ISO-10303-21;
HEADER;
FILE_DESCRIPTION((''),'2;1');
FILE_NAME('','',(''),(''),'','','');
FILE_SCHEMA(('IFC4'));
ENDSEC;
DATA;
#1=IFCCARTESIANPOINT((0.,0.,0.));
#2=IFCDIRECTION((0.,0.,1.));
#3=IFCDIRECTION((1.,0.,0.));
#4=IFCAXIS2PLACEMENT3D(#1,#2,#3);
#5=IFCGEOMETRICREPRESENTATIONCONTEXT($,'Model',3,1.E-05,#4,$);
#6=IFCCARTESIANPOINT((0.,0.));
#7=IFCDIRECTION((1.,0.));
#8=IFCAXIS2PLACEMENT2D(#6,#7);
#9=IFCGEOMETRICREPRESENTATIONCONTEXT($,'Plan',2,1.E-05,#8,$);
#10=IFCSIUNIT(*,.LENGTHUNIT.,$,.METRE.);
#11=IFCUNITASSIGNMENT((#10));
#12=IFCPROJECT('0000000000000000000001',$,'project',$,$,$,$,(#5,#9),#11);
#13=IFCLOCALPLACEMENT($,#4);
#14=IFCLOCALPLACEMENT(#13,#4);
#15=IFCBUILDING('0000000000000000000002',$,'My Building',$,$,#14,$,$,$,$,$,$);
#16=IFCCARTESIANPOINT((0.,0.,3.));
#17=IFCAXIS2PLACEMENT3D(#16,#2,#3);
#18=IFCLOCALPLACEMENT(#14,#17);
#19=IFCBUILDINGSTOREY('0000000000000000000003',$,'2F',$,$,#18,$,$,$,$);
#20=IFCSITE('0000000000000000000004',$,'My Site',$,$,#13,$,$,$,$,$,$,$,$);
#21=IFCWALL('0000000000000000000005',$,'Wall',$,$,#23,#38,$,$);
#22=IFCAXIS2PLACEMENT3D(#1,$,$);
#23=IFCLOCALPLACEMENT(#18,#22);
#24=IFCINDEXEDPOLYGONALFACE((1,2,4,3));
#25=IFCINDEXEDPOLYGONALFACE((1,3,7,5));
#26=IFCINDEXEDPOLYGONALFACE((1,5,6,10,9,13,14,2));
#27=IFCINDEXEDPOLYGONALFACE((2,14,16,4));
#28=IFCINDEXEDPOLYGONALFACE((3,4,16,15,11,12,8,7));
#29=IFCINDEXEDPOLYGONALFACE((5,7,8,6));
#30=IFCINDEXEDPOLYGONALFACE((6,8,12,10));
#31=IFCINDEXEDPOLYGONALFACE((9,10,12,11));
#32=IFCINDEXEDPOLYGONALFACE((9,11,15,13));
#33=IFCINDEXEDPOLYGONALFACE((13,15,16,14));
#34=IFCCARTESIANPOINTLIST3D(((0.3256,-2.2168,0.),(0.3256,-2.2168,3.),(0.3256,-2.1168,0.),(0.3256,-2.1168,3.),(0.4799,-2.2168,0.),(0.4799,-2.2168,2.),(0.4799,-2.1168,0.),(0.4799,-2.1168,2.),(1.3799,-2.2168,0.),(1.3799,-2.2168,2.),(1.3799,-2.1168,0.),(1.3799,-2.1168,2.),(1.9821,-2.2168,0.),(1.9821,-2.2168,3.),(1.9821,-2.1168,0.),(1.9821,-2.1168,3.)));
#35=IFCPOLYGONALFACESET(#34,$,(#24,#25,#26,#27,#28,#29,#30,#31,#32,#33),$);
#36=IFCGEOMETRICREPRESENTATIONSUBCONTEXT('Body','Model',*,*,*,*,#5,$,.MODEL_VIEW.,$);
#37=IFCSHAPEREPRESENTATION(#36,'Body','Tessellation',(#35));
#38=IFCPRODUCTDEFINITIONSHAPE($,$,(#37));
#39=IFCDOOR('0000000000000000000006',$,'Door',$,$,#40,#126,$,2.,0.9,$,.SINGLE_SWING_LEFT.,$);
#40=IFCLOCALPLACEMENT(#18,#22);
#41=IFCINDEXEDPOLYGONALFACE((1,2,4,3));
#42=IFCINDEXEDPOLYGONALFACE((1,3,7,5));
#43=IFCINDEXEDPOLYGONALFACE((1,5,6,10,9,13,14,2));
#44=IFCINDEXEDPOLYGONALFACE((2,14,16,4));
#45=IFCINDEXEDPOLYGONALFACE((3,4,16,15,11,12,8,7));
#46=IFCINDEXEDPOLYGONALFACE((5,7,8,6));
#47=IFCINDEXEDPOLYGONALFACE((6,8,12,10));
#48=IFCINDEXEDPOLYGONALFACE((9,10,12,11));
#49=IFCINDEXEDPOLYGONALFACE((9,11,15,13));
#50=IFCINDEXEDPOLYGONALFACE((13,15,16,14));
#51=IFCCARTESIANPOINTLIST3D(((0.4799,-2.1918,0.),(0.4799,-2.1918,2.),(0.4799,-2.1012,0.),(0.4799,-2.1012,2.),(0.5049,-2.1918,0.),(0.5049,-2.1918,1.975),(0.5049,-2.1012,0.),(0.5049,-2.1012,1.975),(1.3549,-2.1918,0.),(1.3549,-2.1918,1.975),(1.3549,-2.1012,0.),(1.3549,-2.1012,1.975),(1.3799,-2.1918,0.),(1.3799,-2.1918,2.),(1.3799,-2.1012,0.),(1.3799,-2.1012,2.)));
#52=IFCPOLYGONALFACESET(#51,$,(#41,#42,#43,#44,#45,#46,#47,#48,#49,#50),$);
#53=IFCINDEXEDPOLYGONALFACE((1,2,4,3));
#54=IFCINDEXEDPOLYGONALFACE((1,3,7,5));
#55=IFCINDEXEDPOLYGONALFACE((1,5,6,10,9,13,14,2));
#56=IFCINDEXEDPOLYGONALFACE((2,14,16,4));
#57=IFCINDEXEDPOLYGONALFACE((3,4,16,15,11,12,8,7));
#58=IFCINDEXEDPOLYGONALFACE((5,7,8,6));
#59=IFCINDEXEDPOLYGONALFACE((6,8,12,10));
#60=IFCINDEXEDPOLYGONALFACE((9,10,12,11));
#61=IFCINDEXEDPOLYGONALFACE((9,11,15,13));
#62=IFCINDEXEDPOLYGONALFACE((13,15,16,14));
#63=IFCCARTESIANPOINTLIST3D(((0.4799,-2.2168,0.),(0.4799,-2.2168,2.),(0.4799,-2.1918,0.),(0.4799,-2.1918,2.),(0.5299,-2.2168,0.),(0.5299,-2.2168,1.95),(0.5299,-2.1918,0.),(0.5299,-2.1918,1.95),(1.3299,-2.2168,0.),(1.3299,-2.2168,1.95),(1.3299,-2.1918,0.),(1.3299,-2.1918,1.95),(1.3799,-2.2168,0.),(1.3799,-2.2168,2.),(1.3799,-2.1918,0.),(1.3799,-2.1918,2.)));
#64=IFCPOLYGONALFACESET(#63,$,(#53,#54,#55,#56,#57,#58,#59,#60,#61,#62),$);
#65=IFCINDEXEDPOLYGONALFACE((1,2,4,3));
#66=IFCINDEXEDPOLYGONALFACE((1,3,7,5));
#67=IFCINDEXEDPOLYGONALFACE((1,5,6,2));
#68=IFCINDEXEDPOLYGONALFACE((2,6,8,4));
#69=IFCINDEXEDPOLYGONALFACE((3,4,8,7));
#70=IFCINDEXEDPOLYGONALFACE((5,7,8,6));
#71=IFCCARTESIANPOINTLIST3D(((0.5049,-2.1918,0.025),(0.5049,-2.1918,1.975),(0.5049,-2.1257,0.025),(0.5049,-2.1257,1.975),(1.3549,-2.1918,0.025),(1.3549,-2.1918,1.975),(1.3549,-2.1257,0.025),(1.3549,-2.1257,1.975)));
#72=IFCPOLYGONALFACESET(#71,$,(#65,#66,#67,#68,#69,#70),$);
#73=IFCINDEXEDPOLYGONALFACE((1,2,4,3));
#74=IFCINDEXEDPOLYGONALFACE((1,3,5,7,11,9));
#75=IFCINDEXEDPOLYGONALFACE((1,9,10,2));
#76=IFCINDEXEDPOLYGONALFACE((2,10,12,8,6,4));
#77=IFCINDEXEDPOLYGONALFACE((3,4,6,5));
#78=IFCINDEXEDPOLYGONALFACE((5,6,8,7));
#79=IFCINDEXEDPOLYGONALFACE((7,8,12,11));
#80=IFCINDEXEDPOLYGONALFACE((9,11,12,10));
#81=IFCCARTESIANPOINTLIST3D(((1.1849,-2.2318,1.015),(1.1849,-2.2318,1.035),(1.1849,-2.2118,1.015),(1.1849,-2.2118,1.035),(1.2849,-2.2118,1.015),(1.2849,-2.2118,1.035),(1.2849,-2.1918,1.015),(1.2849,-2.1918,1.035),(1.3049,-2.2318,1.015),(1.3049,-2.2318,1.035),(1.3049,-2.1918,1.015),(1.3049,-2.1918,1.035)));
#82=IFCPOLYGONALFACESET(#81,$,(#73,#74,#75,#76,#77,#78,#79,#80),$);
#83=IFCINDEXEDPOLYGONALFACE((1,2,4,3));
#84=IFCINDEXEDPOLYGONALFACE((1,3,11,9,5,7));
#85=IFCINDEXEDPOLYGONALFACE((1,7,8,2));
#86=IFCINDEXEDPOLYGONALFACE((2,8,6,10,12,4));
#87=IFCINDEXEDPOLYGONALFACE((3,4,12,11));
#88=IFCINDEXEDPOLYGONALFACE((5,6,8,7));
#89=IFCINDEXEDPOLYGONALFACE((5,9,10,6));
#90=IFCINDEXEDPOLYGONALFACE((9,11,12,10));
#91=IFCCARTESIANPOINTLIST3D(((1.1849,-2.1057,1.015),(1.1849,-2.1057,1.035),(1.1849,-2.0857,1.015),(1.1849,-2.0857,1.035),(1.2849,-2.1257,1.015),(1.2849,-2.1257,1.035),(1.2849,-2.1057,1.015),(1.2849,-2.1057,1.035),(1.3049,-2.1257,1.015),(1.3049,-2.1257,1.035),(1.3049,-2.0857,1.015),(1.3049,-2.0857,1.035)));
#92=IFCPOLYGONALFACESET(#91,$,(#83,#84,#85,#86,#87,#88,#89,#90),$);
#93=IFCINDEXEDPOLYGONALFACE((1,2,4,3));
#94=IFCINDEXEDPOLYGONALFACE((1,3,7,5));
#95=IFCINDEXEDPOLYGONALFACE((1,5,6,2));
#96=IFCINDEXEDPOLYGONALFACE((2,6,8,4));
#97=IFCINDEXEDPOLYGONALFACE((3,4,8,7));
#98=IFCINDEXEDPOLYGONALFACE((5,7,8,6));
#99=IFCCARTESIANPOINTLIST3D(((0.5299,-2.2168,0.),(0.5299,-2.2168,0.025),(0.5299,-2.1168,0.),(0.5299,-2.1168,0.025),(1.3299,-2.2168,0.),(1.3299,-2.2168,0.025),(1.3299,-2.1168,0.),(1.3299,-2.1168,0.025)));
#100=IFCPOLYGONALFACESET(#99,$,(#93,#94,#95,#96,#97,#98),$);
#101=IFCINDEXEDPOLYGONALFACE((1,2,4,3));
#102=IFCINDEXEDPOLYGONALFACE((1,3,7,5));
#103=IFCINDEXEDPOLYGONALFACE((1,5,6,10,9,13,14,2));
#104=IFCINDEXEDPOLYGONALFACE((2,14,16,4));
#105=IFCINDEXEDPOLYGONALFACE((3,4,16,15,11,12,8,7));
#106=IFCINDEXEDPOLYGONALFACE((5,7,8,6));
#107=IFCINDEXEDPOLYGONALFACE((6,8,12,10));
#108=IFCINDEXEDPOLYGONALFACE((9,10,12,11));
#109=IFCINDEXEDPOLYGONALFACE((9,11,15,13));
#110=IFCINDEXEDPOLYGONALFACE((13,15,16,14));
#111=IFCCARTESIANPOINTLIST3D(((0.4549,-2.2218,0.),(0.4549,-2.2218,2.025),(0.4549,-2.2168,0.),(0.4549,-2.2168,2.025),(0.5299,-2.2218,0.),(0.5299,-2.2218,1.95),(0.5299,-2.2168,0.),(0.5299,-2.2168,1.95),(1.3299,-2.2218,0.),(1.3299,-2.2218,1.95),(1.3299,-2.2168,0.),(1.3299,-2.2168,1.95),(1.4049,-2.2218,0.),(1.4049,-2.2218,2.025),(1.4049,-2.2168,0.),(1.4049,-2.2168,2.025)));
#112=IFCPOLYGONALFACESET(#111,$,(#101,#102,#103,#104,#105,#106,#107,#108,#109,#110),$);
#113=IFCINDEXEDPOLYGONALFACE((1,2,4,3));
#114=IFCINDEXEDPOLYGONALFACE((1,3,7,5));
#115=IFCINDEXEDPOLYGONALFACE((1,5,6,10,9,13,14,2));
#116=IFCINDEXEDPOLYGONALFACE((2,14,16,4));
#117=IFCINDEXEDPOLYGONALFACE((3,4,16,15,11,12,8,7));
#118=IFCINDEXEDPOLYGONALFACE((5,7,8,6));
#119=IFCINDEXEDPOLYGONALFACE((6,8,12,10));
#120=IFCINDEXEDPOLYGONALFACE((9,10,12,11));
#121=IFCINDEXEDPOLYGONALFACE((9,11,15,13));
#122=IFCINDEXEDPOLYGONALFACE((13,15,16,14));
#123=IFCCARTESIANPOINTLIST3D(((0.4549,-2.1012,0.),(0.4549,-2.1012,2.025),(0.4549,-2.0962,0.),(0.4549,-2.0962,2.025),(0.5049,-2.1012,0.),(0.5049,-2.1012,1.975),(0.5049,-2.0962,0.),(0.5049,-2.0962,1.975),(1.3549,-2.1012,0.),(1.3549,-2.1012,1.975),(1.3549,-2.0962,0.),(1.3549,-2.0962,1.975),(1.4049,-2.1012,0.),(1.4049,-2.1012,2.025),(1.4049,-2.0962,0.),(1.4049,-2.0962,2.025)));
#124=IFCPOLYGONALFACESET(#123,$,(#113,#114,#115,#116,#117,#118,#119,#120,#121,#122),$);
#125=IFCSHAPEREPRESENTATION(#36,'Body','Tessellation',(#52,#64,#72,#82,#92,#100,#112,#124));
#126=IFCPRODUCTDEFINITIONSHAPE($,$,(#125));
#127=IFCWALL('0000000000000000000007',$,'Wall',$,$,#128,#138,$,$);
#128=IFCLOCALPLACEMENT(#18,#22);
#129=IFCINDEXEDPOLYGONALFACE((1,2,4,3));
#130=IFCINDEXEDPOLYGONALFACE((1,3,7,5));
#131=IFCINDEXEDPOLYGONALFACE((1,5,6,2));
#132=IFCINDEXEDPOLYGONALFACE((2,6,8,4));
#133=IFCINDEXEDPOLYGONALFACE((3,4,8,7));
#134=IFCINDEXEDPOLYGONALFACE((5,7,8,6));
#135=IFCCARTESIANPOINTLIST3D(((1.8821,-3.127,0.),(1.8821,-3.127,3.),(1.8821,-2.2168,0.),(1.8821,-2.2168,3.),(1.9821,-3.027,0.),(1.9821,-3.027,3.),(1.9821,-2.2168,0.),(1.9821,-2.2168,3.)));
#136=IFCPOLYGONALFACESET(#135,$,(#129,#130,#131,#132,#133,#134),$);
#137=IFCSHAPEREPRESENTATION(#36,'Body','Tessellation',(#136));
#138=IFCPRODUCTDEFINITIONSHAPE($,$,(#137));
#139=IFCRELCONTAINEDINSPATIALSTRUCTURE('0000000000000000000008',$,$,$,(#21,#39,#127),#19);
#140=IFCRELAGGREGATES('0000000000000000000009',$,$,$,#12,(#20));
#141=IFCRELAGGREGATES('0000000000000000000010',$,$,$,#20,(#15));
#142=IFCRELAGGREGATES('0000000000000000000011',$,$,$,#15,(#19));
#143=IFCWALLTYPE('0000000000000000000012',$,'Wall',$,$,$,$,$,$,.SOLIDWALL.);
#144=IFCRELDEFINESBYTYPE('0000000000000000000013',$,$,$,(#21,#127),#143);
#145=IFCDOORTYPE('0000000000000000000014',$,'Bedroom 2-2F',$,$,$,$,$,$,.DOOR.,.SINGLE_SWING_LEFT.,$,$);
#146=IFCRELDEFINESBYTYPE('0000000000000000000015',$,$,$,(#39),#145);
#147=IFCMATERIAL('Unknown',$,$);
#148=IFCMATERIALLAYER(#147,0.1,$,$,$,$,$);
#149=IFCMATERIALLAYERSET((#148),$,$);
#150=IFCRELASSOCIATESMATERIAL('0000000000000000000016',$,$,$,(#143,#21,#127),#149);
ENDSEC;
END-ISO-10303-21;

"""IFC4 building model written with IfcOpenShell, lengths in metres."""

from ifc_helpers import new_model, entity, si_unit, frame, origin_with_axes, origin_2d_with_axis, place, context, subcontext, project, spatial, line, indexed_curve, outline, extrude, shape, source, transform, mapped, material, layer, layer_set, layer_usage, type_object, type_shapes, element, fill, save


model = new_model("IFC4")

# Units and contexts
model_context = context("Model", 3, precision=1e-05, world=origin_with_axes())
plan_context = context("Plan", 2, precision=1e-05, world=origin_2d_with_axis())
body_context_1 = subcontext(model_context, "Body", "Model", "MODEL_VIEW")
body_context_2 = subcontext(plan_context, "Body", "Plan", "PLAN_VIEW")
ifc_project = project(units=[si_unit("LENGTHUNIT", "METRE")], contexts=[model_context, plan_context])

# Site, building, storey
site_placement = place(None, origin_with_axes())
site = spatial("IfcSite", under=ifc_project, at=site_placement, Name="My Site")
building_placement = place(site_placement, origin_with_axes())
building = spatial("IfcBuilding", under=site, at=building_placement, Name="My Building")
storey_placement = place(building_placement, frame((0.0, 0.0, 3.0), z_axis=(0.0, 0.0, 1.0), x_axis=(1.0, 0.0, 0.0)))
storey = spatial("IfcBuildingStorey", under=building, at=storey_placement, Name="2F")

# Shared definitions
ifc_material = material(Name="Unknown")

# Shared definitions
ifc_layer = layer(ifc_material, 0.1)
ifc_layer_set = layer_set([ifc_layer])
wall_type = type_object("IfcWallType", Name="Wall", PredefinedType="SOLIDWALL", material=ifc_layer_set)

# Wall, opening, door
ifc_layer_usage_1 = layer_usage(ifc_layer_set, "AXIS2", "POSITIVE", 0.0)
wall_1_placement = place(storey_placement, frame((0.3256, -2.2168, 0.0), z_axis=(0.0, 0.0, 1.0), x_axis=(1.0, 0.0, 0.0)))
wall_1 = element("IfcWall", 1, at=wall_1_placement, inside=storey, type_object=wall_type, material=ifc_layer_usage_1, Name="Wall", context=body_context_1, shape_type="SweptSolid", body=[
    extrude(outline(indexed_curve([(0.0, 0.0), (0.0, 0.1), (1.6565, 0.1), (1.6565, 0.0)], segments=[line(1, 2, 3, 4, 1)])), origin_with_axes(), (0.0, 0.0, 1.0), 3.0),
])
shared_shape_1 = source(origin_with_axes(), body_context_1, "Body", "SweptSolid", [
    extrude(outline(indexed_curve([(0.0, 0.0), (0.9, 0.0), (0.9, 2.0), (0.0, 2.0)], segments=[line(1, 2, 3, 4, 1)])), frame((0.0, -0.6, 0.0), z_axis=(0.0, -1.0, 0.0), x_axis=(1.0, 0.0, 0.0)), (0.0, 0.0, -1.0), 1.2),
])
opening_1_placement = place(wall_1_placement, frame((0.1543, 0.0, 0.0), z_axis=(0.0, 0.0, 1.0), x_axis=(1.0, 0.0, 0.0)))
opening_1 = element("IfcOpeningElement", 2, at=opening_1_placement, cuts=wall_1, PredefinedType="OPENING", context=body_context_1, shape_type="MappedRepresentation", body=[
    mapped(shared_shape_1, transform((0.0, 0.0, 0.0), x_axis=(1.0, 0.0, 0.0), y_axis=(0.0, 1.0, 0.0), z_axis=(0.0, 0.0, 1.0), scale=1.0)),
])
door_type_1 = type_object("IfcDoorType", Name="Bedroom 2-2F", OperationType="SINGLE_SWING_LEFT", PredefinedType="DOOR")
shared_shape_2 = source(origin_with_axes(), body_context_1, "Body", "SweptSolid", [
    extrude(outline(indexed_curve([(0.0, 0.0), (0.0, 2.0), (0.9, 2.0), (0.9, 0.0), (0.875, 0.0), (0.875, 1.975), (0.025, 1.975), (0.025, 0.0)], segments=[line(1, 2, 3, 4, 5, 6, 7, 8, 1)])), frame((0.0, 0.025, 0.0), z_axis=(0.0, -1.0, 0.0), x_axis=(1.0, 0.0, 0.0)), (0.0, 0.0, -1.0), 0.0906),
    extrude(outline(indexed_curve([(0.0, 0.0), (0.0, 2.0), (0.9, 2.0), (0.9, 0.0), (0.85, 0.0), (0.85, 1.95), (0.05, 1.95), (0.05, 0.0)], segments=[line(1, 2, 3, 4, 5, 6, 7, 8, 1)])), frame((0.0, 0.0, 0.0), z_axis=(0.0, -1.0, 0.0), x_axis=(1.0, 0.0, 0.0)), (0.0, 0.0, -1.0), 0.025),
    extrude(outline(indexed_curve([(0.0, 0.0), (0.85, 0.0), (0.85, 0.0661), (0.0, 0.0661)], segments=[line(1, 2, 3, 4, 1)])), frame((0.025, 0.025, 0.025), z_axis=(0.0, 0.0, 1.0), x_axis=(1.0, 0.0, 0.0)), (0.0, 0.0, 1.0), 1.95),
    extrude(outline(indexed_curve([(0.0, 0.0), (0.0, -0.04), (-0.12, -0.04), (-0.12, -0.02), (-0.02, -0.02), (-0.02, 0.0)], segments=[line(1, 2, 3, 4, 5, 6, 1)])), frame((0.825, 0.025, 1.015), z_axis=(0.0, 0.0, 1.0), x_axis=(1.0, 0.0, 0.0)), (0.0, 0.0, 1.0), 0.02),
    extrude(outline(indexed_curve([(0.0, 0.0), (0.0, 0.04), (-0.12, 0.04), (-0.12, 0.02), (-0.02, 0.02), (-0.02, 0.0)], segments=[line(1, 2, 3, 4, 5, 6, 1)])), frame((0.825, 0.0911, 1.015), z_axis=(0.0, 0.0, 1.0), x_axis=(1.0, 0.0, 0.0)), (0.0, 0.0, 1.0), 0.02),
    extrude(outline(indexed_curve([(0.0, 0.0), (0.8, 0.0), (0.8, 0.1), (0.0, 0.1)], segments=[line(1, 2, 3, 4, 1)])), frame((0.05, 0.0, 0.0), z_axis=(0.0, 0.0, 1.0), x_axis=(1.0, 0.0, 0.0)), (0.0, 0.0, 1.0), 0.025),
    extrude(outline(indexed_curve([(0.0, 0.0), (0.0, 2.025), (0.95, 2.025), (0.95, 0.0), (0.875, 0.0), (0.875, 1.95), (0.075, 1.95), (0.075, 0.0)], segments=[line(1, 2, 3, 4, 5, 6, 7, 8, 1)])), frame((-0.025, -0.005, 0.0), z_axis=(0.0, -1.0, 0.0), x_axis=(1.0, 0.0, 0.0)), (0.0, 0.0, -1.0), 0.005),
    extrude(outline(indexed_curve([(0.0, 0.0), (0.0, 2.025), (0.95, 2.025), (0.95, 0.0), (0.9, 0.0), (0.9, 1.975), (0.05, 1.975), (0.05, 0.0)], segments=[line(1, 2, 3, 4, 5, 6, 7, 8, 1)])), frame((-0.025, 0.1156, 0.0), z_axis=(0.0, -1.0, 0.0), x_axis=(1.0, 0.0, 0.0)), (0.0, 0.0, -1.0), 0.005),
])
shared_shape_3 = source(origin_with_axes(), body_context_2, "Body", "Curve2D", [
    entity("IfcIndexedPolyCurve", entity("IfcCartesianPointList2D", [[0.0, 0.0], [0.0, 0.1156], [0.025, 0.1156], [0.025, 0.025], [0.05, 0.025], [0.05, 0.0]]), [entity("IfcLineIndex", [1, 2, 3, 4, 5, 6, 1])]),
    entity("IfcIndexedPolyCurve", entity("IfcCartesianPointList2D", [[0.9, 0.0], [0.9, 0.1156], [0.875, 0.1156], [0.875, 0.025], [0.85, 0.025], [0.85, 0.0]]), [entity("IfcLineIndex", [1, 2, 3, 4, 5, 6, 1])]),
    entity("IfcTrimmedCurve", entity("IfcEllipse", entity("IfcAxis2Placement2D", entity("IfcCartesianPoint", [0.0911, 0.1156]), entity("IfcDirection", [1.0, 0.0])), 0.7839, 0.85), [entity("IfcCartesianPoint", [0.875, 0.1156])], [entity("IfcCartesianPoint", [0.0911, 0.9656])], True, "CARTESIAN"),
    entity("IfcIndexedPolyCurve", entity("IfcCartesianPointList2D", [[0.025, 0.1156], [0.0911, 0.1156], [0.0911, 0.9656], [0.025, 0.9656]]), [entity("IfcLineIndex", [1, 2, 3, 4, 1])]),
])
type_shapes(door_type_1, [shared_shape_2, shared_shape_3])
door_1_placement = place(opening_1_placement, frame((0.0, 0.0, 0.0), z_axis=(0.0, 0.0, 1.0), x_axis=(1.0, 0.0, 0.0)))
door_1 = element("IfcDoor", 3, at=door_1_placement, inside=storey, type_object=door_type_1, Name="Door", OperationType="SINGLE_SWING_LEFT", OverallHeight=2.0, OverallWidth=0.9, shapes=[
    shape(body_context_1, "Body", "MappedRepresentation", [mapped(shared_shape_2, transform((0.0, 0.0, 0.0), x_axis=(1.0, 0.0, 0.0), y_axis=(0.0, 1.0, 0.0), z_axis=(0.0, 0.0, 1.0), scale=1.0))]),
    shape(body_context_2, "Body", "MappedRepresentation", [mapped(shared_shape_3, transform((0.0, 0.0, 0.0), x_axis=(1.0, 0.0, 0.0), y_axis=(0.0, 1.0, 0.0), z_axis=(0.0, 0.0, 1.0), scale=1.0))]),
])
fill(opening_1, door_1)

# Wall
ifc_layer_usage_2 = layer_usage(ifc_layer_set, "AXIS2", "POSITIVE", 0.0)
wall_2_placement = place(storey_placement, frame((1.8821, -2.2168, 0.0), z_axis=(0.0, 0.0, 1.0), x_axis=(0.0, -1.0, 0.0)))
element("IfcWall", 4, at=wall_2_placement, inside=storey, type_object=wall_type, material=ifc_layer_usage_2, Name="Wall", context=body_context_1, shape_type="SweptSolid", body=[
    extrude(outline(indexed_curve([(0.0, 0.0), (0.0, 0.1), (0.8102, 0.1), (0.9102, 0.0)], segments=[line(1, 2, 3, 4, 1)])), origin_with_axes(), (0.0, 0.0, 1.0), 3.0),
])

save(model, "model.ifc")
